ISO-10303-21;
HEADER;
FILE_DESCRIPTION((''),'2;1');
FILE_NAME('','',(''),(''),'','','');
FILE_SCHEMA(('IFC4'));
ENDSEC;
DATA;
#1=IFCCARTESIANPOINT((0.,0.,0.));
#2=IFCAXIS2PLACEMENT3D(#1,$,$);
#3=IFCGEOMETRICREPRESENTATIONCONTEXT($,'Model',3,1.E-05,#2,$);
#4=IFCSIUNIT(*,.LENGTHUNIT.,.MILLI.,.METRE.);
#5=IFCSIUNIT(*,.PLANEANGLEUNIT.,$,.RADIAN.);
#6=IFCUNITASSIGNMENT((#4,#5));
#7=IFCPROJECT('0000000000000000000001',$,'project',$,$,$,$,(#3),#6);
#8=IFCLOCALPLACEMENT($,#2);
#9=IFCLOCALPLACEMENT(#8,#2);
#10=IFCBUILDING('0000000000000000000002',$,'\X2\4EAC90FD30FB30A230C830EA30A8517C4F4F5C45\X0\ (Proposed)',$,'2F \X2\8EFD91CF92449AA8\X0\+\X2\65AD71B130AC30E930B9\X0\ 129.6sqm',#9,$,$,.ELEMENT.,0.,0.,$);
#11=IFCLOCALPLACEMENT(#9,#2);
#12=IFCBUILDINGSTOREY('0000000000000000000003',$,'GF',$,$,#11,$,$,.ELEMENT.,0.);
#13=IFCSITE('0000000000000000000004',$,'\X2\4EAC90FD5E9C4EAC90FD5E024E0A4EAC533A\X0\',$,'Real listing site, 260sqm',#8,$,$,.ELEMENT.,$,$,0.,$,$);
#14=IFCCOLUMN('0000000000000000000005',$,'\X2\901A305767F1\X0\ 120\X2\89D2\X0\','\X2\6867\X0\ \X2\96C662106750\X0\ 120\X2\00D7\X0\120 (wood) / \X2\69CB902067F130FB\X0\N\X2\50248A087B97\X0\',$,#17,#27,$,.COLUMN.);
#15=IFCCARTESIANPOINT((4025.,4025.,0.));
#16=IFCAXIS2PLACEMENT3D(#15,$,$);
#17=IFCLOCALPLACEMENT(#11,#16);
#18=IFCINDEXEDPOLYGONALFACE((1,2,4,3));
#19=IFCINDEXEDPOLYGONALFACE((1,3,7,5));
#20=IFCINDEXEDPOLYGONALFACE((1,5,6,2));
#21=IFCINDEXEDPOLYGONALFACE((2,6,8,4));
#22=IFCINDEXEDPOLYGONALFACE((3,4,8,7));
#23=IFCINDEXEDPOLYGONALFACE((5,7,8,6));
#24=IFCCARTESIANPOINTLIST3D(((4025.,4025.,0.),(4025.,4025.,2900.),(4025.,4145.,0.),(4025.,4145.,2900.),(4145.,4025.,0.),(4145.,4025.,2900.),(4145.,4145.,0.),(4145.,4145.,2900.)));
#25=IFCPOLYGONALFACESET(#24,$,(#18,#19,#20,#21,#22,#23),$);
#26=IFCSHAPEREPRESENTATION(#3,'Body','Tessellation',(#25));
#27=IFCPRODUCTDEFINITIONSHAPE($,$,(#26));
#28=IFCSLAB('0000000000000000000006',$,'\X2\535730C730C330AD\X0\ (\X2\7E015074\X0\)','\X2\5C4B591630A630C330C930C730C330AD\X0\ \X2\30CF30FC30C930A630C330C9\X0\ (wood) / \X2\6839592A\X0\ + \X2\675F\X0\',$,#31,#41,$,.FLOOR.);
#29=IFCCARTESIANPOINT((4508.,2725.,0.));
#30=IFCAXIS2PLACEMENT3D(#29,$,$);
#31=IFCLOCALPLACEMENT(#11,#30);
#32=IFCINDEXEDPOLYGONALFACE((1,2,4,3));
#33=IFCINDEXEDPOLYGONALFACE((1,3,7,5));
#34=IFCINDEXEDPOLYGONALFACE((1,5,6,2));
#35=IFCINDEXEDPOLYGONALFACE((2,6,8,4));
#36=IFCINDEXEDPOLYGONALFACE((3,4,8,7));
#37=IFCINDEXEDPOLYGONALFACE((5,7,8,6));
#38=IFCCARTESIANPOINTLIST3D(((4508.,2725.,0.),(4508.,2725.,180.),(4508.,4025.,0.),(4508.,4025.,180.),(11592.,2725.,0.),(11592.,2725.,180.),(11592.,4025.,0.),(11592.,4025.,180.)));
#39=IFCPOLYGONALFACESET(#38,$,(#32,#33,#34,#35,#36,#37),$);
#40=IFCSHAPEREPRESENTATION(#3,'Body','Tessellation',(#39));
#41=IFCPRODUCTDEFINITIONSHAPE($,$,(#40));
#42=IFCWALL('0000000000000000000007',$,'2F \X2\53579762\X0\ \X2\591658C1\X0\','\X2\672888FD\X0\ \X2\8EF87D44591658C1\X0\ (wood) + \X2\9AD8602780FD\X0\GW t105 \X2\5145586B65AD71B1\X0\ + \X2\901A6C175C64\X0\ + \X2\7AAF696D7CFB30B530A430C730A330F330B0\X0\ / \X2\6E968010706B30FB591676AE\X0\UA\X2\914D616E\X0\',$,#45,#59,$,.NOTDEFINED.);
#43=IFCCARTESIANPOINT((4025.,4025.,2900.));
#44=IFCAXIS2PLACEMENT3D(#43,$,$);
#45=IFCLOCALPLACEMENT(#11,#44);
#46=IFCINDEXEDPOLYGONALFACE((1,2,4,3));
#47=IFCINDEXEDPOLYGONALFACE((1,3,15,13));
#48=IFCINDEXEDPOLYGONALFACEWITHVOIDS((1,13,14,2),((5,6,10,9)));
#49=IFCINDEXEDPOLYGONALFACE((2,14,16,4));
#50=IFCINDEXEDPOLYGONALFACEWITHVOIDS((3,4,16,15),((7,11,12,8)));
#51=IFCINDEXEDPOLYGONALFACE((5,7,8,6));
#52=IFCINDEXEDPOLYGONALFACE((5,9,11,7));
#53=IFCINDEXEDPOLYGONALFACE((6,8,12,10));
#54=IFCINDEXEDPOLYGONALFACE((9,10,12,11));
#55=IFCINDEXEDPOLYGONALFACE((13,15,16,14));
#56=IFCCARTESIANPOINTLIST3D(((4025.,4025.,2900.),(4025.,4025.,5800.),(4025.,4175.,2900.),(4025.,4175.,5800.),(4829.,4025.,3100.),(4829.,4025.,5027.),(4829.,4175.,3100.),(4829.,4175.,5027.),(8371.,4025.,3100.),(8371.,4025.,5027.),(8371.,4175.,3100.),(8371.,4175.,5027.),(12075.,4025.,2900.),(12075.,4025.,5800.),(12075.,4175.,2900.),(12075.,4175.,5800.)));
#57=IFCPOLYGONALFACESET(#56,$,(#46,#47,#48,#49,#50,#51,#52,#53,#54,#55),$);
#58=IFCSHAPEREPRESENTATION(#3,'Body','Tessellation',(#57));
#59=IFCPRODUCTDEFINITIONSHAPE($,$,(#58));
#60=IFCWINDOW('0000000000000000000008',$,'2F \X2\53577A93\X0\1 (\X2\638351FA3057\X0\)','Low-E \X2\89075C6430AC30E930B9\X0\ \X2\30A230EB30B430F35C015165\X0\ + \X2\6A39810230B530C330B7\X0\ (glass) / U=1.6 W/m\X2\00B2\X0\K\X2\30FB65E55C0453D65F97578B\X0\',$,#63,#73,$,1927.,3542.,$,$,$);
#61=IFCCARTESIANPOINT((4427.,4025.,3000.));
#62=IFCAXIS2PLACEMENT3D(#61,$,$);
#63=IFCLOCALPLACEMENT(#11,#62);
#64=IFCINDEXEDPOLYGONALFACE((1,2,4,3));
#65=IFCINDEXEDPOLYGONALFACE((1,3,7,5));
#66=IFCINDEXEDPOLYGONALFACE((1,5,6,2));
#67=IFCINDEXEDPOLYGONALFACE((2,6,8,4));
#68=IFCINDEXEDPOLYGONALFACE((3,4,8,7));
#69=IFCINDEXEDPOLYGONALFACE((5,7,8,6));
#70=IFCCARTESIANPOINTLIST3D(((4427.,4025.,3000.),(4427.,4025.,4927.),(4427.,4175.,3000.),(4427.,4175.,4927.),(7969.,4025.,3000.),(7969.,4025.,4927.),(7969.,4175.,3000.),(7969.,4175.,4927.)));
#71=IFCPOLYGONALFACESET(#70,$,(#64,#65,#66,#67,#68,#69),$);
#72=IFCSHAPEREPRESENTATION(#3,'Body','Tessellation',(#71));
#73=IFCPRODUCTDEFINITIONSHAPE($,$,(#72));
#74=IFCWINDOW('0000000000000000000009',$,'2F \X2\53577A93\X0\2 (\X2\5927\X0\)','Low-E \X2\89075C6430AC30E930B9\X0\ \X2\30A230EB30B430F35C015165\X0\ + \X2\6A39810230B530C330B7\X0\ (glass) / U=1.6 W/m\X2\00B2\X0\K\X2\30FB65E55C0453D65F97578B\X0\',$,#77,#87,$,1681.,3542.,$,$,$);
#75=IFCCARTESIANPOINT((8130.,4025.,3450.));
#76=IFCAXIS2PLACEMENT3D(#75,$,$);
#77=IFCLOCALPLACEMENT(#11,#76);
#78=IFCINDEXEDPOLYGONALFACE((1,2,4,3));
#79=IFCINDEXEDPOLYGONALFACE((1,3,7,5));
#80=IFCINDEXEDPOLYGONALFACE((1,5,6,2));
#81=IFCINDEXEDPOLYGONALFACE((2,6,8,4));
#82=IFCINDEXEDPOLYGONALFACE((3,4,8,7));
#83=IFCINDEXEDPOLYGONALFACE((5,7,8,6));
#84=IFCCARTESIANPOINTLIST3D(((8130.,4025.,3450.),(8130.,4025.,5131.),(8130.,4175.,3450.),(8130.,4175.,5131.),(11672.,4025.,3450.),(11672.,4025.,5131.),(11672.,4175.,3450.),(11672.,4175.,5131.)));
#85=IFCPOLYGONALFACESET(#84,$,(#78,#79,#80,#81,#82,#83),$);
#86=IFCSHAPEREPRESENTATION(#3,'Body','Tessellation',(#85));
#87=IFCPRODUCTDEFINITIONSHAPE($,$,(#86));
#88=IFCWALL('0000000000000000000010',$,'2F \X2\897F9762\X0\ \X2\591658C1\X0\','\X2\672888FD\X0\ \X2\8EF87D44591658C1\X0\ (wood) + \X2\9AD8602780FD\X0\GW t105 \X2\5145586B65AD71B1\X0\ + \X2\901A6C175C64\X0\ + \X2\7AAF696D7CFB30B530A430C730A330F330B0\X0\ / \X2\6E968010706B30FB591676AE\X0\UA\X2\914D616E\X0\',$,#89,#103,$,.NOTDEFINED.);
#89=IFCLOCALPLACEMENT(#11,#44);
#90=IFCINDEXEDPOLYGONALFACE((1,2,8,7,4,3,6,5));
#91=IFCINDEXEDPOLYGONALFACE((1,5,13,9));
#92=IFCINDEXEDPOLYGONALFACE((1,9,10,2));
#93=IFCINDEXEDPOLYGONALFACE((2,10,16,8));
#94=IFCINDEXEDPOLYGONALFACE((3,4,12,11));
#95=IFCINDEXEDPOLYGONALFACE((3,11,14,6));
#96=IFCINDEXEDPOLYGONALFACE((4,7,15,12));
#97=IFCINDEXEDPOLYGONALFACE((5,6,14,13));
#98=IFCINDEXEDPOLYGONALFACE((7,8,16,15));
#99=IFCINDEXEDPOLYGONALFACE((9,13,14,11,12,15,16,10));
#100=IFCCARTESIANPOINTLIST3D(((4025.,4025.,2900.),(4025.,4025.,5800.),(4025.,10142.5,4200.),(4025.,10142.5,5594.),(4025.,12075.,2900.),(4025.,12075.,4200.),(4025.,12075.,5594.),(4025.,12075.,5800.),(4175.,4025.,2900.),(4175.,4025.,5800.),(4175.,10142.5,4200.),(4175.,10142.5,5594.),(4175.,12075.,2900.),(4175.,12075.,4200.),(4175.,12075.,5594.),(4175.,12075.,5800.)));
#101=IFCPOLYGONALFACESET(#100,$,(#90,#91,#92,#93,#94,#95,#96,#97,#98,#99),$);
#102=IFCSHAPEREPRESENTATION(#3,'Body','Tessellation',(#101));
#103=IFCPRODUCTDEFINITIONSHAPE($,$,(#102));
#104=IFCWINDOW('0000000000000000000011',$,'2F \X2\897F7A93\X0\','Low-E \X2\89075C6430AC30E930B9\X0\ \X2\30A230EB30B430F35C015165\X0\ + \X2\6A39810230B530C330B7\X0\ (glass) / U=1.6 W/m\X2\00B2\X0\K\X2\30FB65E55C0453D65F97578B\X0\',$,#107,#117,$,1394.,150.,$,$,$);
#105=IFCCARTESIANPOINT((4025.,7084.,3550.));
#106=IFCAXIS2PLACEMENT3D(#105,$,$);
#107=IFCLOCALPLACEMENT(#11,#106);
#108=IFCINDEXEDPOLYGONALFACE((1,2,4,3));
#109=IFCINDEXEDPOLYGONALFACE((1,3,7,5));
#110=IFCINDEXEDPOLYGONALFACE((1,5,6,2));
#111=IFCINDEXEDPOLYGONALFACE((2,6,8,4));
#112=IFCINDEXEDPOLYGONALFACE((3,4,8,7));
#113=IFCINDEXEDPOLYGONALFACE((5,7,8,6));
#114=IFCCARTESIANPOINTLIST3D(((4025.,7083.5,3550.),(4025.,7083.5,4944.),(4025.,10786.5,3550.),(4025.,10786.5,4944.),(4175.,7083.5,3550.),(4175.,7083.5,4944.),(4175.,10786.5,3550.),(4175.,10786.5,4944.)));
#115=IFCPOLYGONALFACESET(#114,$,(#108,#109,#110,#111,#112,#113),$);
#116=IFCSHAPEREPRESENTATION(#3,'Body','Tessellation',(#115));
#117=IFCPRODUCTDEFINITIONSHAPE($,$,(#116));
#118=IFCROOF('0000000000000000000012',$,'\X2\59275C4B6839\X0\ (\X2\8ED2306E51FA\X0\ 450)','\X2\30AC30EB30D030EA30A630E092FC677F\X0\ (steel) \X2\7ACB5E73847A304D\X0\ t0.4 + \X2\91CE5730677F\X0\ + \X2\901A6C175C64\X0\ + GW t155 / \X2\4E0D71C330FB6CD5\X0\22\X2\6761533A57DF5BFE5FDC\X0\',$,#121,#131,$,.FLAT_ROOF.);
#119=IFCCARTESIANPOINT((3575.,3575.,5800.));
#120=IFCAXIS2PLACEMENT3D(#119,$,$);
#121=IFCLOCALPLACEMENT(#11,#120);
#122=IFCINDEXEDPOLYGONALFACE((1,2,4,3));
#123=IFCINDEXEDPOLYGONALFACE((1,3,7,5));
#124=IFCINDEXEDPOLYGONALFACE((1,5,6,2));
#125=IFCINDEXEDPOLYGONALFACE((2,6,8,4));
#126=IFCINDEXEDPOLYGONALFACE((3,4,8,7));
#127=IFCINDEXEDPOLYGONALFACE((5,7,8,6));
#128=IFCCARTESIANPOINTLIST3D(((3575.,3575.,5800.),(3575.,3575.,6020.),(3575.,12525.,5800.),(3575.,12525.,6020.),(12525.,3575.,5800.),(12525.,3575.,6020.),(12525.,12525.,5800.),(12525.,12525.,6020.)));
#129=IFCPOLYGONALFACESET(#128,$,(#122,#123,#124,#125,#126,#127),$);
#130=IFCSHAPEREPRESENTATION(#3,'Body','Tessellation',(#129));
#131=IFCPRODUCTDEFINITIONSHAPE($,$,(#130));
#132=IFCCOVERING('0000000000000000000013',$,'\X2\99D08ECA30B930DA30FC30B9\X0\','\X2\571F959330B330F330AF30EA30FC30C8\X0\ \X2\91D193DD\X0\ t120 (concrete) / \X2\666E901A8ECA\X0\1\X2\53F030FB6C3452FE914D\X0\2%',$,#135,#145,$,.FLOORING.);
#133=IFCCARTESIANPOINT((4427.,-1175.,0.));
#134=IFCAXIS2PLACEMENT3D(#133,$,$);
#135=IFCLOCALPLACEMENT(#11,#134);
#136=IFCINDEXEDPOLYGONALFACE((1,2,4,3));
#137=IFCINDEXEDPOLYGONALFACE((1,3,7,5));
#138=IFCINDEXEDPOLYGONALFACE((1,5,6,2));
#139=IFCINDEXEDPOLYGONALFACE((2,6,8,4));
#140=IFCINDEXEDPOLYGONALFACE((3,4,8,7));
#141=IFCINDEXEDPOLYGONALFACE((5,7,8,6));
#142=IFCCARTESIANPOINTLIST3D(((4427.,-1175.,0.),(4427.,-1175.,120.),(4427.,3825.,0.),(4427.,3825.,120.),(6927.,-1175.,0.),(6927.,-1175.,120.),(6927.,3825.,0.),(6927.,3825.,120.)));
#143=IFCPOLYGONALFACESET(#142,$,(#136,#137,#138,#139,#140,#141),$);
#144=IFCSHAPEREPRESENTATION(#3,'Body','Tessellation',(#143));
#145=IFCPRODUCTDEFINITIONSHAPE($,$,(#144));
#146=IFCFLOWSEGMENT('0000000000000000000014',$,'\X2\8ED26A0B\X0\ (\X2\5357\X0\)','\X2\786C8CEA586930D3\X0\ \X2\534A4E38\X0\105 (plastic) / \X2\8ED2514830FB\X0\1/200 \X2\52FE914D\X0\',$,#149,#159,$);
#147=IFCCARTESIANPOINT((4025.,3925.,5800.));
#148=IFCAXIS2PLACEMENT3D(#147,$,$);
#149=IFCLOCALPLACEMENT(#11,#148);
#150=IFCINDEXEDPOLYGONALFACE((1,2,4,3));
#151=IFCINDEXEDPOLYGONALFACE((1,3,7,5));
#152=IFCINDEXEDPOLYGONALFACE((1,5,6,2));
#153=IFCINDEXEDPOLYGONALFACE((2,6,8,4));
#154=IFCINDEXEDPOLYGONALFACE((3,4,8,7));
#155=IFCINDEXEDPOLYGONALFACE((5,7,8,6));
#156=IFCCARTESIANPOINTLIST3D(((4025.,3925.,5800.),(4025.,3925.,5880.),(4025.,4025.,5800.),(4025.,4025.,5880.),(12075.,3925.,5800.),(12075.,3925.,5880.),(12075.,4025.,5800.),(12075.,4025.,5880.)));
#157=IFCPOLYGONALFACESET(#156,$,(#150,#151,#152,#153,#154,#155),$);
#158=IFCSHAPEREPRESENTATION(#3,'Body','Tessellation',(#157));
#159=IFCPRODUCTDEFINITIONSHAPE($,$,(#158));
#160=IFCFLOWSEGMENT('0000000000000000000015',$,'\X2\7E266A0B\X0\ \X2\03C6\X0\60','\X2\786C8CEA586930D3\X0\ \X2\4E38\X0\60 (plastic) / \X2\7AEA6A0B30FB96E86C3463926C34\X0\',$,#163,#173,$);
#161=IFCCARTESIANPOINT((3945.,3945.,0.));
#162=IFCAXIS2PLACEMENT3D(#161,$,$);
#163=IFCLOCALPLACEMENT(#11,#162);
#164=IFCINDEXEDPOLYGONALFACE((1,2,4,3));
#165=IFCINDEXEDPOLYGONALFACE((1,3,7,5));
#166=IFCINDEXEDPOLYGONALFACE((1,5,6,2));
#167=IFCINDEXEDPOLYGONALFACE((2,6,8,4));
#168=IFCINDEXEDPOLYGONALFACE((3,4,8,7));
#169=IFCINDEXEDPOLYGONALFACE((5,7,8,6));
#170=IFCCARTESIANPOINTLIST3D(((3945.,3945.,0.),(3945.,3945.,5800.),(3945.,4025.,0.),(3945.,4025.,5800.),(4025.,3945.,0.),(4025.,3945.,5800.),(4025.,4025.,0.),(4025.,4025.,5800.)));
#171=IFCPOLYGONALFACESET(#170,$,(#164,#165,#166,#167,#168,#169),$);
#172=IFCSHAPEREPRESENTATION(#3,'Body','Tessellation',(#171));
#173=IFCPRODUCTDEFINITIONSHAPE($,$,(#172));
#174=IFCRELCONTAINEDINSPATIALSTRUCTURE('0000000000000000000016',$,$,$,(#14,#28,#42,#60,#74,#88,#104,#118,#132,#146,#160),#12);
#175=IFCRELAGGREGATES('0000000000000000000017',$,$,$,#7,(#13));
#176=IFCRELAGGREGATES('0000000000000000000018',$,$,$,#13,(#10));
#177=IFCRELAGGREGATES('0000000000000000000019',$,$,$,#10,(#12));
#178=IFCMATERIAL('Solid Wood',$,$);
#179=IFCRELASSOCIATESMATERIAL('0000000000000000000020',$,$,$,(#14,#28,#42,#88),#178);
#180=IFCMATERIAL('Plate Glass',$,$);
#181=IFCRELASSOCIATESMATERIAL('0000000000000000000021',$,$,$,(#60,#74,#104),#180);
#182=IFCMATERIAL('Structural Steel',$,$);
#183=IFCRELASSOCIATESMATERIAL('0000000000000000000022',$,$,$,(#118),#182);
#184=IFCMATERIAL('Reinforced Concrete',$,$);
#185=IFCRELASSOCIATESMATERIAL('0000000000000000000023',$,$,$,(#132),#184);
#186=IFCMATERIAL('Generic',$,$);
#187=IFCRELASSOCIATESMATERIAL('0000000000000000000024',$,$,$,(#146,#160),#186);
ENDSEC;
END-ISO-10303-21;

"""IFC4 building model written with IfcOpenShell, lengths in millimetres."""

from ifc_helpers import new_model, si_unit, frame, frame_2d, origin, place, context, project, spatial, rectangle, extrude, material, element, fill, save


model = new_model("IFC4")

# Units and contexts
model_context = context("Model", 3, precision=1e-05, world=origin())
ifc_project = project(units=[si_unit("LENGTHUNIT", "METRE", prefix="MILLI"), si_unit("PLANEANGLEUNIT", "RADIAN")], contexts=[model_context])

# Site, building, storey
site_placement = place(None, origin())
site = spatial("IfcSite", under=ifc_project, at=site_placement, Name="京都府京都市上京区", ObjectType="Real listing site, 260sqm", CompositionType="ELEMENT", RefElevation=0.0)
building_placement = place(site_placement, origin())
building = spatial("IfcBuilding", under=site, at=building_placement, Name="京都・アトリエ兼住居 (Proposed)", ObjectType="2F 軽量鉄骨+断熱ガラス 129.6sqm", CompositionType="ELEMENT", ElevationOfRefHeight=0.0, ElevationOfTerrain=0.0)
storey_placement = place(building_placement, origin())
storey = spatial("IfcBuildingStorey", under=building, at=storey_placement, Name="GF", CompositionType="ELEMENT", Elevation=0.0)

# Column
ifc_material_1 = material(Name="Solid Wood")
column_placement = place(storey_placement, frame((4025.0, 4025.0, 0.0)))
element("IfcColumn", 1, at=column_placement, inside=storey, material=ifc_material_1, Name="通し柱 120角", Description="桧 集成材 120×120 (wood) / 構造柱・N値計算", PredefinedType="COLUMN", context=model_context, shape_type="SweptSolid", body=[
    extrude(rectangle(XDim=120.0, YDim=120.0, at=frame_2d((60.0, 60.0))), frame((4025.0, 4025.0, 0.0)), (0.0, 0.0, 1.0), 2900.0),
])

# Slab
ifc_material_2 = material(Name="Reinforced Concrete")
slab_1_placement = place(storey_placement, frame((4508.0, 2725.0, 0.0)))
element("IfcSlab", 2, at=slab_1_placement, inside=storey, material=ifc_material_1, Name="南デッキ (縁側)", Description="屋外ウッドデッキ ハードウッド (wood) / 根太 + 束", PredefinedType="FLOOR", context=model_context, shape_type="SweptSolid", body=[
    extrude(rectangle(XDim=7084.0, YDim=1300.0, at=frame_2d((3542.0, 650.0))), frame((4508.0, 2725.0, 0.0)), (0.0, 0.0, 1.0), 180.0),
])

# Shared definitions
ifc_material_3 = material(Name="Plate Glass")

# Wall, openings, windows
wall_1_placement = place(storey_placement, frame((4025.0, 4025.0, 2900.0)))
wall_1 = element("IfcWall", 3, at=wall_1_placement, inside=storey, material=ifc_material_1, Name="2F 南面 外壁", Description="木製 軸組外壁 (wood) + 高性能GW t105 充填断熱 + 通気層 + 窯業系サイディング / 準耐火・外皮UA配慮", PredefinedType="NOTDEFINED", context=model_context, shape_type="SweptSolid", body=[
    extrude(rectangle(XDim=8050.0, YDim=150.0, at=frame_2d((4025.0, 75.0))), frame((4025.0, 4025.0, 2900.0)), (0.0, 0.0, 1.0), 2900.0),
])
opening_1_placement = place(storey_placement, frame((4427.0, 4025.0, 3000.0)))
opening_1 = element("IfcOpeningElement", 4, at=opening_1_placement, cuts=wall_1, PredefinedType="NOTDEFINED", context=model_context, shape_type="SweptSolid", body=[
    extrude(rectangle(XDim=3542.0, YDim=150.0, at=frame_2d((1771.0, 75.0))), frame((4427.0, 4025.0, 3000.0)), (0.0, 0.0, 1.0), 1927.0),
])
opening_2_placement = place(storey_placement, frame((8130.0, 4025.0, 3450.0)))
opening_2 = element("IfcOpeningElement", 5, at=opening_2_placement, cuts=wall_1, PredefinedType="NOTDEFINED", context=model_context, shape_type="SweptSolid", body=[
    extrude(rectangle(XDim=3542.0, YDim=150.0, at=frame_2d((1771.0, 75.0))), frame((8130.0, 4025.0, 3450.0)), (0.0, 0.0, 1.0), 1681.0),
])
window_1_placement = place(storey_placement, frame((4427.0, 4025.0, 3000.0)))
window_1 = element("IfcWindow", 6, at=window_1_placement, inside=storey, material=ifc_material_3, Name="2F 南窓1 (掃出し)", Description="Low-E 複層ガラス アルゴン封入 + 樹脂サッシ (glass) / U=1.6 W/m²K・日射取得型", OverallHeight=1927.0, OverallWidth=3542.0, context=model_context, shape_type="SweptSolid", body=[
    extrude(rectangle(XDim=3542.0, YDim=150.0, at=frame_2d((1771.0, 75.0))), frame((4427.0, 4025.0, 3000.0)), (0.0, 0.0, 1.0), 1927.0),
])
fill(opening_1, window_1)
window_2_placement = place(storey_placement, frame((8130.0, 4025.0, 3450.0)))
window_2 = element("IfcWindow", 7, at=window_2_placement, inside=storey, material=ifc_material_3, Name="2F 南窓2 (大)", Description="Low-E 複層ガラス アルゴン封入 + 樹脂サッシ (glass) / U=1.6 W/m²K・日射取得型", OverallHeight=1681.0, OverallWidth=3542.0, context=model_context, shape_type="SweptSolid", body=[
    extrude(rectangle(XDim=3542.0, YDim=150.0, at=frame_2d((1771.0, 75.0))), frame((8130.0, 4025.0, 3450.0)), (0.0, 0.0, 1.0), 1681.0),
])
fill(opening_2, window_2)

# Wall, opening, window
wall_2_placement = place(storey_placement, frame((4025.0, 4025.0, 2900.0)))
wall_2 = element("IfcWall", 8, at=wall_2_placement, inside=storey, material=ifc_material_1, Name="2F 西面 外壁", Description="木製 軸組外壁 (wood) + 高性能GW t105 充填断熱 + 通気層 + 窯業系サイディング / 準耐火・外皮UA配慮", PredefinedType="NOTDEFINED", context=model_context, shape_type="SweptSolid", body=[
    extrude(rectangle(XDim=150.0, YDim=8050.0, at=frame_2d((75.0, 4025.0))), frame((4025.0, 4025.0, 2900.0)), (0.0, 0.0, 1.0), 2900.0),
])
opening_3_placement = place(storey_placement, frame((4025.0, 7084.0, 3550.0)))
opening_3 = element("IfcOpeningElement", 9, at=opening_3_placement, cuts=wall_2, PredefinedType="NOTDEFINED", context=model_context, shape_type="SweptSolid", body=[
    extrude(rectangle(XDim=150.0, YDim=3703.0, at=frame_2d((75.0, 1851.0))), frame((4025.0, 7084.0, 3550.0)), (0.0, 0.0, 1.0), 1394.0),
])
window_3_placement = place(storey_placement, frame((4025.0, 7084.0, 3550.0)))
window_3 = element("IfcWindow", 10, at=window_3_placement, inside=storey, material=ifc_material_3, Name="2F 西窓", Description="Low-E 複層ガラス アルゴン封入 + 樹脂サッシ (glass) / U=1.6 W/m²K・日射取得型", OverallHeight=1394.0, OverallWidth=150.0, context=model_context, shape_type="SweptSolid", body=[
    extrude(rectangle(XDim=150.0, YDim=3703.0, at=frame_2d((75.0, 1851.0))), frame((4025.0, 7084.0, 3550.0)), (0.0, 0.0, 1.0), 1394.0),
])
fill(opening_3, window_3)

# Roof
ifc_material_4 = material(Name="Structural Steel")
roof_placement = place(storey_placement, frame((3575.0, 3575.0, 5800.0)))
element("IfcRoof", 11, at=roof_placement, inside=storey, material=ifc_material_4, Name="大屋根 (軒の出 450)", Description="ガルバリウム鋼板 (steel) 立平葺き t0.4 + 野地板 + 通気層 + GW t155 / 不燃・法22条区域対応", PredefinedType="FLAT_ROOF", context=model_context, shape_type="SweptSolid", body=[
    extrude(rectangle(XDim=8950.0, YDim=8950.0, at=frame_2d((4475.0, 4475.0))), frame((3575.0, 3575.0, 5800.0)), (0.0, 0.0, 1.0), 220.0),
])

# Covering
covering_placement = place(storey_placement, frame((4427.0, -1175.0, 0.0)))
element("IfcCovering", 12, at=covering_placement, inside=storey, material=ifc_material_2, Name="駐車スペース", Description="土間コンクリート 金鏝 t120 (concrete) / 普通車1台・水勾配2%", PredefinedType="FLOORING", context=model_context, shape_type="SweptSolid", body=[
    extrude(rectangle(XDim=2500.0, YDim=5000.0, at=frame_2d((1250.0, 2500.0))), frame((4427.0, -1175.0, 0.0)), (0.0, 0.0, 1.0), 120.0),
])

# Flow segments
ifc_material_5 = material(Name="Generic")
flow_segment_1_placement = place(storey_placement, frame((4025.0, 3925.0, 5800.0)))
element("IfcFlowSegment", 13, at=flow_segment_1_placement, inside=storey, material=ifc_material_5, Name="軒樋 (南)", Description="硬質塩ビ 半丸105 (plastic) / 軒先・1/200 勾配", context=model_context, shape_type="SweptSolid", body=[
    extrude(rectangle(XDim=8050.0, YDim=100.0, at=frame_2d((4025.0, 50.0))), frame((4025.0, 3925.0, 5800.0)), (0.0, 0.0, 1.0), 80.0),
])
flow_segment_2_placement = place(storey_placement, frame((3945.0, 3945.0, 0.0)))
element("IfcFlowSegment", 14, at=flow_segment_2_placement, inside=storey, material=ifc_material_5, Name="縦樋 φ60", Description="硬質塩ビ 丸60 (plastic) / 竪樋・雨水排水", context=model_context, shape_type="SweptSolid", body=[
    extrude(rectangle(XDim=80.0, YDim=80.0, at=frame_2d((40.0, 40.0))), frame((3945.0, 3945.0, 0.0)), (0.0, 0.0, 1.0), 5800.0),
])

save(model, "model.ifc")
